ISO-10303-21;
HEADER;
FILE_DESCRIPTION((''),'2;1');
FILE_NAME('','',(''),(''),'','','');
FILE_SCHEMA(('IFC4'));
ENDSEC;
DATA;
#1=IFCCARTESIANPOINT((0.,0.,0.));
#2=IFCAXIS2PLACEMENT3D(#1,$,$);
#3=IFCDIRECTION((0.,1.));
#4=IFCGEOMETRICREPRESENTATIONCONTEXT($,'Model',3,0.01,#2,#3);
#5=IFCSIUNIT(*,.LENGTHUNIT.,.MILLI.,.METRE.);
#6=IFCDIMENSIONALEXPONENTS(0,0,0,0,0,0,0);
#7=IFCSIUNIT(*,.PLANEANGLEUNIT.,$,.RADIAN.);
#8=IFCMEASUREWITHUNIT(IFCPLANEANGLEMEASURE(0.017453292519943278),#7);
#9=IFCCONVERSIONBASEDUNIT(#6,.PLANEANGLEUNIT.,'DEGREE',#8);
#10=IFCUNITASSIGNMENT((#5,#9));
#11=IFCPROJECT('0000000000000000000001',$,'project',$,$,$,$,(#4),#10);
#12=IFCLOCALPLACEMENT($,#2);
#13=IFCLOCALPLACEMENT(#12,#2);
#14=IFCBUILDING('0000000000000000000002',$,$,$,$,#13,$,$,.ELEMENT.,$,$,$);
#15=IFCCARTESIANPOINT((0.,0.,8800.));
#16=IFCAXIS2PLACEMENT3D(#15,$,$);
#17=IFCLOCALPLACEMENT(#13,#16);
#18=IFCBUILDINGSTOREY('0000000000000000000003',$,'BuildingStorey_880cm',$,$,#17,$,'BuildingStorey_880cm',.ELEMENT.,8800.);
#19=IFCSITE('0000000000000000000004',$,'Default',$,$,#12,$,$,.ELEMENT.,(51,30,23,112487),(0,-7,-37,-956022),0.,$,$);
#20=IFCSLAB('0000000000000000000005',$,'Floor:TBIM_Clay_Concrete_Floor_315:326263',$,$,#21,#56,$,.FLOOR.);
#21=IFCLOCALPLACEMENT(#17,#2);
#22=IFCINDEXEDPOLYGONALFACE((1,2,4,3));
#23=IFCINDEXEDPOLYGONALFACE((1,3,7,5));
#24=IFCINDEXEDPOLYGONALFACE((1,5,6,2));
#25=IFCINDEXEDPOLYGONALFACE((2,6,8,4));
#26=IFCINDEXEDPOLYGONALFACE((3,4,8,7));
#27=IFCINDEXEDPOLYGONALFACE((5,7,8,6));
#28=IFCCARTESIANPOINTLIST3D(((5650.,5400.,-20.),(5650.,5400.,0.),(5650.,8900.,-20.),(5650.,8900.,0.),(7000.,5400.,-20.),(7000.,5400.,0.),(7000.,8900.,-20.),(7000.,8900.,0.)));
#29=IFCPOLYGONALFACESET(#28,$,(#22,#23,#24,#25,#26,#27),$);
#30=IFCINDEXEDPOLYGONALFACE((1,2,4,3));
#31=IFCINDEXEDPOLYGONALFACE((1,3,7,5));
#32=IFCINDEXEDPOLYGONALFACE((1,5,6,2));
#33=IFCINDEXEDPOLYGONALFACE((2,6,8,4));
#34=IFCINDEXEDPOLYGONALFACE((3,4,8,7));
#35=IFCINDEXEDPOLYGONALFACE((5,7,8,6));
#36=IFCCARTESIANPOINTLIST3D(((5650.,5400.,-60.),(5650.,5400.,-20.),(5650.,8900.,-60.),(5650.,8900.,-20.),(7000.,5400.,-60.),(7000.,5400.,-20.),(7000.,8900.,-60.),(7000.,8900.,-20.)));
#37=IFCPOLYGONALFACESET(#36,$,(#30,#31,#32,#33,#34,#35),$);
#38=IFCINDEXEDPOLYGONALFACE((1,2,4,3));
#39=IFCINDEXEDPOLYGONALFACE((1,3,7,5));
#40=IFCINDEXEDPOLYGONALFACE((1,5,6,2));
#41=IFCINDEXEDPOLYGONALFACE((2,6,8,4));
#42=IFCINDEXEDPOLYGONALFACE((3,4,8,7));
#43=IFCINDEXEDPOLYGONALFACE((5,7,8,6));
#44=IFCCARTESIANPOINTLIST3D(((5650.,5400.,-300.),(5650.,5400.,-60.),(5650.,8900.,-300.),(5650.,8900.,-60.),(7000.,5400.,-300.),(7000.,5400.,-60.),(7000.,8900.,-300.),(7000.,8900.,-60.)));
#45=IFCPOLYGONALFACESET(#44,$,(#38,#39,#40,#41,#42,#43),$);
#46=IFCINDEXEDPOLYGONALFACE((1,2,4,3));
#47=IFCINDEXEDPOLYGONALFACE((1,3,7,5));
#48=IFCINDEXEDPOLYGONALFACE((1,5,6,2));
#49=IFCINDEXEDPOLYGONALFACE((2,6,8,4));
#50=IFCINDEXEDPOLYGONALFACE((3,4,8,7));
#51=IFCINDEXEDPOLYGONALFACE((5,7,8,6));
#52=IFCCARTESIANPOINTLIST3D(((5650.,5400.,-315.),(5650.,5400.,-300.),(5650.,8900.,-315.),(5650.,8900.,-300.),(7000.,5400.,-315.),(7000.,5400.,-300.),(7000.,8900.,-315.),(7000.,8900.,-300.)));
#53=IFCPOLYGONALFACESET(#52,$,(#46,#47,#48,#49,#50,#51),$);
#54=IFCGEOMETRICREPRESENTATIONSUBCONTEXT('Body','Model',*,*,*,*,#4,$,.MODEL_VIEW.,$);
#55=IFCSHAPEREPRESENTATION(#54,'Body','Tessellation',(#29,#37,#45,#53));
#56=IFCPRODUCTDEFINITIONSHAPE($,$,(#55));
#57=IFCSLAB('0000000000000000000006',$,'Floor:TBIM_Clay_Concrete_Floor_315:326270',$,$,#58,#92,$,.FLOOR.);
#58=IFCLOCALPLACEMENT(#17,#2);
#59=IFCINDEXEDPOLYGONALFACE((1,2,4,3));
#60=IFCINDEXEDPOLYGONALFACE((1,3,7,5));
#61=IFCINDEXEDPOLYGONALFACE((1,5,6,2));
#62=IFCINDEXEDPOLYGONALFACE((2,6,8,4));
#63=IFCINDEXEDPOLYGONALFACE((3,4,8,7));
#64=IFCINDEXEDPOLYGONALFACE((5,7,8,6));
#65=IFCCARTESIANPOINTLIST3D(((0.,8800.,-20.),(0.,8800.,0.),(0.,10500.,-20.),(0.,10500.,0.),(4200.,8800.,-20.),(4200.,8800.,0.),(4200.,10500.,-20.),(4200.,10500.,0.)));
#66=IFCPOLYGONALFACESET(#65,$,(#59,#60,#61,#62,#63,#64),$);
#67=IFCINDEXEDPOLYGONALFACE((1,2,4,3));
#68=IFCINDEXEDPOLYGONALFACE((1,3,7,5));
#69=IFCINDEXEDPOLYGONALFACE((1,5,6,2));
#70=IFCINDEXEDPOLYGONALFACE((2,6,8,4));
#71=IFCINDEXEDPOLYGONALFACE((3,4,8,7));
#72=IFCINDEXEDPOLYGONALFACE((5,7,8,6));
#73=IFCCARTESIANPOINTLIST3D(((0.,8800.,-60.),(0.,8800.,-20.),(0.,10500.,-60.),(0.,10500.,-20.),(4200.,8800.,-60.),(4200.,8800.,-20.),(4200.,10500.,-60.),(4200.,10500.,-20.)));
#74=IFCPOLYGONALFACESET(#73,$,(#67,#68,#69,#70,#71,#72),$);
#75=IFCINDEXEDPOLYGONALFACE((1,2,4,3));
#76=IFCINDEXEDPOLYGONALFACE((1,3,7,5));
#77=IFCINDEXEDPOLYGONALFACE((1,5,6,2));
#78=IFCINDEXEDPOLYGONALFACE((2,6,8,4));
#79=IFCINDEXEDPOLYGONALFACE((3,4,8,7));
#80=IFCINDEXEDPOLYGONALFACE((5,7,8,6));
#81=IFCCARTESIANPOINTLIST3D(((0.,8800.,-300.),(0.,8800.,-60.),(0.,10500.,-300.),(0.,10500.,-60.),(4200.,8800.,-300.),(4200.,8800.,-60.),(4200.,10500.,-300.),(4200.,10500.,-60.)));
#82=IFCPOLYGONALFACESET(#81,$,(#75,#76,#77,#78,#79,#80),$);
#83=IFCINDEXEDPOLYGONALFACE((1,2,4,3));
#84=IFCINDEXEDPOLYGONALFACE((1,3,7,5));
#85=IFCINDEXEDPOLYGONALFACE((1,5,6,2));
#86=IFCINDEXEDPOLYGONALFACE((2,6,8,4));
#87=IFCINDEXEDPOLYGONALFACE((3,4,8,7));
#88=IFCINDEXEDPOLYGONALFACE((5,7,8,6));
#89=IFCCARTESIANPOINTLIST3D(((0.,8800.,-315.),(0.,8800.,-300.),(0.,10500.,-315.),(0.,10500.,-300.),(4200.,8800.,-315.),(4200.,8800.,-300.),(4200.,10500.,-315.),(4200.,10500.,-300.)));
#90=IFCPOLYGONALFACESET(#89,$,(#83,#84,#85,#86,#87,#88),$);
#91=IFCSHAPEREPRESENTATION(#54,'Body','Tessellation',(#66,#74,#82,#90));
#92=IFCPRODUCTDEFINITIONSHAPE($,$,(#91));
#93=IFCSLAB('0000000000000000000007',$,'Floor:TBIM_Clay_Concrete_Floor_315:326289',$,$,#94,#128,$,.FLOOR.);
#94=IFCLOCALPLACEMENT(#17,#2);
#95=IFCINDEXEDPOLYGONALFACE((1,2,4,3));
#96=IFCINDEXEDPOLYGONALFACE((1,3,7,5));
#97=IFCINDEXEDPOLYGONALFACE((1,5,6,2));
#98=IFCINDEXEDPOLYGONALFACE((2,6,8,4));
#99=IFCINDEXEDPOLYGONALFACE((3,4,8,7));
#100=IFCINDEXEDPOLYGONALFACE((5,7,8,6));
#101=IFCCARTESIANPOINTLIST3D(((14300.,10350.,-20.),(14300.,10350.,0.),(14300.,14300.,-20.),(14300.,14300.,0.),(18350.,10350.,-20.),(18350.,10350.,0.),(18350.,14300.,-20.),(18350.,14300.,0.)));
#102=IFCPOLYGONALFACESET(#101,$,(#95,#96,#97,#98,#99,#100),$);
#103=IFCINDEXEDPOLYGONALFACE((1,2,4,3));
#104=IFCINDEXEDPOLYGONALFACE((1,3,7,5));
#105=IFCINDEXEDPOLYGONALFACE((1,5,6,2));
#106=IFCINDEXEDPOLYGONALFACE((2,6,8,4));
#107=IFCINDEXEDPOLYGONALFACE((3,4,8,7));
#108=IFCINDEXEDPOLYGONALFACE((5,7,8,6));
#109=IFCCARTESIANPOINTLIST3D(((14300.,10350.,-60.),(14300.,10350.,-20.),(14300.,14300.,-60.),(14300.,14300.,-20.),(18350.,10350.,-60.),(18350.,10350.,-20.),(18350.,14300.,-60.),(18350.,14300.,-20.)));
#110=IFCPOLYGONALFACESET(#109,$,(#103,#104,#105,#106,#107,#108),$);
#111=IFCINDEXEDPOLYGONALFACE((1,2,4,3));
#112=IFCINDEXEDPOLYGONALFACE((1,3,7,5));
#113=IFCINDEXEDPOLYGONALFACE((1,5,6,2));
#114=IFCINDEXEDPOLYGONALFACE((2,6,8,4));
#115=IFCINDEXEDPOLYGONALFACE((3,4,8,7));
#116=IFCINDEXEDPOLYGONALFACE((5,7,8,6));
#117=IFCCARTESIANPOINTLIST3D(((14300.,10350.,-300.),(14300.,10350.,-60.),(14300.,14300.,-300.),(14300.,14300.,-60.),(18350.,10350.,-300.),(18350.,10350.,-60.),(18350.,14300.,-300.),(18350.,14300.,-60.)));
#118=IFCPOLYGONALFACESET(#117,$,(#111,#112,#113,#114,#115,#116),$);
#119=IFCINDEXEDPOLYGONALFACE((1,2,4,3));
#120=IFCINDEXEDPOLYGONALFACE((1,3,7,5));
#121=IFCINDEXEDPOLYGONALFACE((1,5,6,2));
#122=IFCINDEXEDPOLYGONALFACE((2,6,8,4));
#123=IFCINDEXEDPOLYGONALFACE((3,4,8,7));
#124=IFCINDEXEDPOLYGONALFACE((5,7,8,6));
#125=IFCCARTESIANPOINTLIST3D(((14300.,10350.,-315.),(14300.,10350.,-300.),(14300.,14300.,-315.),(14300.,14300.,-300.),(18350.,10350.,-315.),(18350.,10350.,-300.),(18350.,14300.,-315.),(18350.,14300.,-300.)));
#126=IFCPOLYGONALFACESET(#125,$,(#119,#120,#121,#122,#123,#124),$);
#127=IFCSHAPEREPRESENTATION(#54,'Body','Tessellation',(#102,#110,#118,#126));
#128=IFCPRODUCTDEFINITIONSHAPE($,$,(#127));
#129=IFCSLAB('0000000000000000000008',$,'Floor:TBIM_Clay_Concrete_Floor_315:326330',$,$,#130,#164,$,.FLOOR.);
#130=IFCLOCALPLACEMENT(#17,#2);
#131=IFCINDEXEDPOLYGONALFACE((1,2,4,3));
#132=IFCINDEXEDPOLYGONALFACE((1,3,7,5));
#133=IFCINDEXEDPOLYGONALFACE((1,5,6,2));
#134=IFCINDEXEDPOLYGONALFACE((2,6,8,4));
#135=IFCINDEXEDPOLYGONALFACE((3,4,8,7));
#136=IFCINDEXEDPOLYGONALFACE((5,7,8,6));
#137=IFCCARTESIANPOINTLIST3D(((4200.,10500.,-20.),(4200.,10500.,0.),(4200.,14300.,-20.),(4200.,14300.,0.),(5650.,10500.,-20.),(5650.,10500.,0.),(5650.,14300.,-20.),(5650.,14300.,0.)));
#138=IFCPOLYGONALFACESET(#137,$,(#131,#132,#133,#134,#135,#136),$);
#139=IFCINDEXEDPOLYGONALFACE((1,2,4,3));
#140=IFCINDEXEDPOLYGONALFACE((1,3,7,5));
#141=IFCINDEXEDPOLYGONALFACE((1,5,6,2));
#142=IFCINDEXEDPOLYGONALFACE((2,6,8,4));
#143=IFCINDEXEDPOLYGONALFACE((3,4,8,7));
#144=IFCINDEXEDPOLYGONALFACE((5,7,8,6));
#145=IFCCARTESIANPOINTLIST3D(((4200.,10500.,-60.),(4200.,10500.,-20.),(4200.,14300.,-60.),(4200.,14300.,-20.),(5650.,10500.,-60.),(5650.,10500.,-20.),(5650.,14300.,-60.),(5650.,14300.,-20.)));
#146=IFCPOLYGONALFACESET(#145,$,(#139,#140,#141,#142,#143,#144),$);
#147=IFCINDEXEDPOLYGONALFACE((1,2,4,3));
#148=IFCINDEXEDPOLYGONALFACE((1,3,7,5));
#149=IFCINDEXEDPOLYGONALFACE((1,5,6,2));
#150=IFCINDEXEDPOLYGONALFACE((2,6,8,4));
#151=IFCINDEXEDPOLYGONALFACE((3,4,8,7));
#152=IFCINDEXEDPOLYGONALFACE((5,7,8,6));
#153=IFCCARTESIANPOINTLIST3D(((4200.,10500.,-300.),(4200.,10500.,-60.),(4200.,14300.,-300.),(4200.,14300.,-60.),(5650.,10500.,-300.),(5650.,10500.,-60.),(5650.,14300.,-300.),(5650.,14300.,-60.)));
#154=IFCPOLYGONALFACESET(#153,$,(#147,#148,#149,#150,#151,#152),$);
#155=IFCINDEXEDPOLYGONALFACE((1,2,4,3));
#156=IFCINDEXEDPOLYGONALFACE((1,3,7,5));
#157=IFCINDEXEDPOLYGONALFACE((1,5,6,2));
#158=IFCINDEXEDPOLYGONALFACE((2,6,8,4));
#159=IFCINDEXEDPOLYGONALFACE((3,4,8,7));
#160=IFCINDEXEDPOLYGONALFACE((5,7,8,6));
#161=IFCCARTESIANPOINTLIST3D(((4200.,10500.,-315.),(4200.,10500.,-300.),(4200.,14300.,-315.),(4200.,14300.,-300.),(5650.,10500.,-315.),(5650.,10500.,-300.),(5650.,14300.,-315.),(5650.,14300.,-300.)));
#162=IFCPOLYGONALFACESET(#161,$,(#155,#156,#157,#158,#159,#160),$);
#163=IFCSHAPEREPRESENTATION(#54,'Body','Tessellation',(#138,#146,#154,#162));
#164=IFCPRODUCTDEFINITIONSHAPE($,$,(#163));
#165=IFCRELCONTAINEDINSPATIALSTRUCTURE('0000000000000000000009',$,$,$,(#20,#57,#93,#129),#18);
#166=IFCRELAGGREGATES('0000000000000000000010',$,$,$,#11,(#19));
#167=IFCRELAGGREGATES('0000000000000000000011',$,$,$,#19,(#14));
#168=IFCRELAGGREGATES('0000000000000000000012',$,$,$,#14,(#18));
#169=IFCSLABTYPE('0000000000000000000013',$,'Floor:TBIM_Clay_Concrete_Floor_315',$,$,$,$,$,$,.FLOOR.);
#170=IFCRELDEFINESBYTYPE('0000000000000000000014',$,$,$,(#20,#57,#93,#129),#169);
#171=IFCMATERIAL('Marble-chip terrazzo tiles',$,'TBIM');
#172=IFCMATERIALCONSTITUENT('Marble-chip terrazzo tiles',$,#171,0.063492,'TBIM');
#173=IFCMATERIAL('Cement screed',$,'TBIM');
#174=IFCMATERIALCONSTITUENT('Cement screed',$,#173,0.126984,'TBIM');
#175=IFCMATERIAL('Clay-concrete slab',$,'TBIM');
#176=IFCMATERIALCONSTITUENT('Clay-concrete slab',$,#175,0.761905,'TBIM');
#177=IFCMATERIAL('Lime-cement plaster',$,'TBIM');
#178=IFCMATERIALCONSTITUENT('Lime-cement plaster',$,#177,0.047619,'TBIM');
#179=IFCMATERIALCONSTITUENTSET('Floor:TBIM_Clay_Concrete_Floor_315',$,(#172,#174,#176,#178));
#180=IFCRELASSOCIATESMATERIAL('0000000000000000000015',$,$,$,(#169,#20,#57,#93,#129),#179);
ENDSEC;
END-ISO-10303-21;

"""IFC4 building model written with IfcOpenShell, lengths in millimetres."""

from ifc_helpers import new_model, entity, si_unit, converted_unit, direction, frame, origin, place, context, subcontext, project, spatial, indexed_curve, outline, extrude, material, constituent, constituent_set, type_object, element, save


model = new_model("IFC4")

# Units and contexts
model_context = context("Model", 3, precision=0.01, world=origin(), true_north=direction((0.0, 1.0)))
body_context = subcontext(model_context, "Body", "Model", "MODEL_VIEW")
ifc_project = project(units=[si_unit("LENGTHUNIT", "METRE", prefix="MILLI"), converted_unit("PLANEANGLEUNIT", "DEGREE", entity("IfcPlaneAngleMeasure", 0.017453292519943278), si_unit("PLANEANGLEUNIT", "RADIAN"), dimensions=[0, 0, 0, 0, 0, 0, 0])], contexts=[model_context])

# Site, building, storey
site_placement = place(None, origin())
site = spatial("IfcSite", under=ifc_project, at=site_placement, Name="Default", CompositionType="ELEMENT", RefLatitude=(51, 30, 23, 112487), RefLongitude=(0, -7, -37, -956022), RefElevation=0.0)
building_placement = place(site_placement, origin())
building = spatial("IfcBuilding", under=site, at=building_placement, CompositionType="ELEMENT")
storey_placement = place(building_placement, frame((0.0, 0.0, 8800.0)))
storey = spatial("IfcBuildingStorey", under=building, at=storey_placement, Name="BuildingStorey_880cm", LongName="BuildingStorey_880cm", CompositionType="ELEMENT", Elevation=8800.0)

# Slabs
ifc_material_1 = material(Name="Marble-chip terrazzo tiles", Category="TBIM")
ifc_constituent_1 = constituent(ifc_material_1, Name="Marble-chip terrazzo tiles", Category="TBIM", fraction=0.063492)
ifc_material_2 = material(Name="Cement screed", Category="TBIM")
ifc_constituent_2 = constituent(ifc_material_2, Name="Cement screed", Category="TBIM", fraction=0.126984)
ifc_material_3 = material(Name="Clay-concrete slab", Category="TBIM")
ifc_constituent_3 = constituent(ifc_material_3, Name="Clay-concrete slab", Category="TBIM", fraction=0.761905)
ifc_material_4 = material(Name="Lime-cement plaster", Category="TBIM")
ifc_constituent_4 = constituent(ifc_material_4, Name="Lime-cement plaster", Category="TBIM", fraction=0.047619)
ifc_constituent_set_1 = constituent_set(constituents=[ifc_constituent_1, ifc_constituent_2, ifc_constituent_3, ifc_constituent_4], Name="Floor:TBIM_Clay_Concrete_Floor_315")
slab_type = type_object("IfcSlabType", Name="Floor:TBIM_Clay_Concrete_Floor_315", PredefinedType="FLOOR", material=ifc_constituent_set_1)
slab_1_placement = place(storey_placement, origin())
element("IfcSlab", 1, at=slab_1_placement, inside=storey, type_object=slab_type, material=ifc_constituent_set_1, Name="Floor:TBIM_Clay_Concrete_Floor_315:326263", PredefinedType="FLOOR", context=body_context, shape_type="SweptSolid", body=[
    extrude(outline(indexed_curve([(-675.0, -1750.0), (675.0, -1750.0), (675.0, 1750.0), (-675.0, 1750.0), (-675.0, -1750.0)], self_intersect=False)), frame((6325.0, 7150.0, -20.0), z_axis=(0.0, 0.0, 1.0), x_axis=(-1.0, 0.0, 0.0)), (0.0, 0.0, 1.0), 20.0),
    extrude(outline(indexed_curve([(-675.0, -1750.0), (675.0, -1750.0), (675.0, 1750.0), (-675.0, 1750.0), (-675.0, -1750.0)], self_intersect=False)), frame((6325.0, 7150.0, -60.0), z_axis=(0.0, 0.0, 1.0), x_axis=(-1.0, 0.0, 0.0)), (0.0, 0.0, 1.0), 40.0),
    extrude(outline(indexed_curve([(-675.0, -1750.0), (675.0, -1750.0), (675.0, 1750.0), (-675.0, 1750.0), (-675.0, -1750.0)], self_intersect=False)), frame((6325.0, 7150.0, -300.0), z_axis=(0.0, 0.0, 1.0), x_axis=(-1.0, 0.0, 0.0)), (0.0, 0.0, 1.0), 240.0),
    extrude(outline(indexed_curve([(-675.0, -1750.0), (675.0, -1750.0), (675.0, 1750.0), (-675.0, 1750.0), (-675.0, -1750.0)], self_intersect=False)), frame((6325.0, 7150.0, -315.0), z_axis=(0.0, 0.0, 1.0), x_axis=(-1.0, 0.0, 0.0)), (0.0, 0.0, 1.0), 15.0),
])
slab_2_placement = place(storey_placement, origin())
element("IfcSlab", 2, at=slab_2_placement, inside=storey, type_object=slab_type, material=ifc_constituent_set_1, Name="Floor:TBIM_Clay_Concrete_Floor_315:326270", PredefinedType="FLOOR", context=body_context, shape_type="SweptSolid", body=[
    extrude(outline(indexed_curve([(-2100.0, -850.0), (2100.0, -850.0), (2100.0, 850.0), (-2100.0, 850.0), (-2100.0, -850.0)], self_intersect=False)), frame((2100.0, 9650.0, -20.0), z_axis=(0.0, 0.0, 1.0), x_axis=(-1.0, 0.0, 0.0)), (0.0, 0.0, 1.0), 20.0),
    extrude(outline(indexed_curve([(-2100.0, -850.0), (2100.0, -850.0), (2100.0, 850.0), (-2100.0, 850.0), (-2100.0, -850.0)], self_intersect=False)), frame((2100.0, 9650.0, -60.0), z_axis=(0.0, 0.0, 1.0), x_axis=(-1.0, 0.0, 0.0)), (0.0, 0.0, 1.0), 40.0),
    extrude(outline(indexed_curve([(-2100.0, -850.0), (2100.0, -850.0), (2100.0, 850.0), (-2100.0, 850.0), (-2100.0, -850.0)], self_intersect=False)), frame((2100.0, 9650.0, -300.0), z_axis=(0.0, 0.0, 1.0), x_axis=(-1.0, 0.0, 0.0)), (0.0, 0.0, 1.0), 240.0),
    extrude(outline(indexed_curve([(-2100.0, -850.0), (2100.0, -850.0), (2100.0, 850.0), (-2100.0, 850.0), (-2100.0, -850.0)], self_intersect=False)), frame((2100.0, 9650.0, -315.0), z_axis=(0.0, 0.0, 1.0), x_axis=(-1.0, 0.0, 0.0)), (0.0, 0.0, 1.0), 15.0),
])
slab_3_placement = place(storey_placement, origin())
element("IfcSlab", 3, at=slab_3_placement, inside=storey, type_object=slab_type, material=ifc_constituent_set_1, Name="Floor:TBIM_Clay_Concrete_Floor_315:326289", PredefinedType="FLOOR", context=body_context, shape_type="SweptSolid", body=[
    extrude(outline(indexed_curve([(-2025.0, -1975.0), (2025.0, -1975.0), (2025.0, 1975.0), (-2025.0, 1975.0), (-2025.0, -1975.0)], self_intersect=False)), frame((16325.0, 12325.0, -20.0), z_axis=(0.0, 0.0, 1.0), x_axis=(-1.0, 0.0, 0.0)), (0.0, 0.0, 1.0), 20.0),
    extrude(outline(indexed_curve([(-2025.0, -1975.0), (2025.0, -1975.0), (2025.0, 1975.0), (-2025.0, 1975.0), (-2025.0, -1975.0)], self_intersect=False)), frame((16325.0, 12325.0, -60.0), z_axis=(0.0, 0.0, 1.0), x_axis=(-1.0, 0.0, 0.0)), (0.0, 0.0, 1.0), 40.0),
    extrude(outline(indexed_curve([(-2025.0, -1975.0), (2025.0, -1975.0), (2025.0, 1975.0), (-2025.0, 1975.0), (-2025.0, -1975.0)], self_intersect=False)), frame((16325.0, 12325.0, -300.0), z_axis=(0.0, 0.0, 1.0), x_axis=(-1.0, 0.0, 0.0)), (0.0, 0.0, 1.0), 240.0),
    extrude(outline(indexed_curve([(-2025.0, -1975.0), (2025.0, -1975.0), (2025.0, 1975.0), (-2025.0, 1975.0), (-2025.0, -1975.0)], self_intersect=False)), frame((16325.0, 12325.0, -315.0), z_axis=(0.0, 0.0, 1.0), x_axis=(-1.0, 0.0, 0.0)), (0.0, 0.0, 1.0), 15.0),
])
slab_4_placement = place(storey_placement, origin())
element("IfcSlab", 4, at=slab_4_placement, inside=storey, type_object=slab_type, material=ifc_constituent_set_1, Name="Floor:TBIM_Clay_Concrete_Floor_315:326330", PredefinedType="FLOOR", context=body_context, shape_type="SweptSolid", body=[
    extrude(outline(indexed_curve([(-725.0, -1900.0), (725.0, -1900.0), (725.0, 1900.0), (-725.0, 1900.0), (-725.0, -1900.0)], self_intersect=False)), frame((4925.0, 12400.0, -20.0), z_axis=(0.0, 0.0, 1.0), x_axis=(-1.0, 0.0, 0.0)), (0.0, 0.0, 1.0), 20.0),
    extrude(outline(indexed_curve([(-725.0, -1900.0), (725.0, -1900.0), (725.0, 1900.0), (-725.0, 1900.0), (-725.0, -1900.0)], self_intersect=False)), frame((4925.0, 12400.0, -60.0), z_axis=(0.0, 0.0, 1.0), x_axis=(-1.0, 0.0, 0.0)), (0.0, 0.0, 1.0), 40.0),
    extrude(outline(indexed_curve([(-725.0, -1900.0), (725.0, -1900.0), (725.0, 1900.0), (-725.0, 1900.0), (-725.0, -1900.0)], self_intersect=False)), frame((4925.0, 12400.0, -300.0), z_axis=(0.0, 0.0, 1.0), x_axis=(-1.0, 0.0, 0.0)), (0.0, 0.0, 1.0), 240.0),
    extrude(outline(indexed_curve([(-725.0, -1900.0), (725.0, -1900.0), (725.0, 1900.0), (-725.0, 1900.0), (-725.0, -1900.0)], self_intersect=False)), frame((4925.0, 12400.0, -315.0), z_axis=(0.0, 0.0, 1.0), x_axis=(-1.0, 0.0, 0.0)), (0.0, 0.0, 1.0), 15.0),
])

save(model, "model.ifc")
